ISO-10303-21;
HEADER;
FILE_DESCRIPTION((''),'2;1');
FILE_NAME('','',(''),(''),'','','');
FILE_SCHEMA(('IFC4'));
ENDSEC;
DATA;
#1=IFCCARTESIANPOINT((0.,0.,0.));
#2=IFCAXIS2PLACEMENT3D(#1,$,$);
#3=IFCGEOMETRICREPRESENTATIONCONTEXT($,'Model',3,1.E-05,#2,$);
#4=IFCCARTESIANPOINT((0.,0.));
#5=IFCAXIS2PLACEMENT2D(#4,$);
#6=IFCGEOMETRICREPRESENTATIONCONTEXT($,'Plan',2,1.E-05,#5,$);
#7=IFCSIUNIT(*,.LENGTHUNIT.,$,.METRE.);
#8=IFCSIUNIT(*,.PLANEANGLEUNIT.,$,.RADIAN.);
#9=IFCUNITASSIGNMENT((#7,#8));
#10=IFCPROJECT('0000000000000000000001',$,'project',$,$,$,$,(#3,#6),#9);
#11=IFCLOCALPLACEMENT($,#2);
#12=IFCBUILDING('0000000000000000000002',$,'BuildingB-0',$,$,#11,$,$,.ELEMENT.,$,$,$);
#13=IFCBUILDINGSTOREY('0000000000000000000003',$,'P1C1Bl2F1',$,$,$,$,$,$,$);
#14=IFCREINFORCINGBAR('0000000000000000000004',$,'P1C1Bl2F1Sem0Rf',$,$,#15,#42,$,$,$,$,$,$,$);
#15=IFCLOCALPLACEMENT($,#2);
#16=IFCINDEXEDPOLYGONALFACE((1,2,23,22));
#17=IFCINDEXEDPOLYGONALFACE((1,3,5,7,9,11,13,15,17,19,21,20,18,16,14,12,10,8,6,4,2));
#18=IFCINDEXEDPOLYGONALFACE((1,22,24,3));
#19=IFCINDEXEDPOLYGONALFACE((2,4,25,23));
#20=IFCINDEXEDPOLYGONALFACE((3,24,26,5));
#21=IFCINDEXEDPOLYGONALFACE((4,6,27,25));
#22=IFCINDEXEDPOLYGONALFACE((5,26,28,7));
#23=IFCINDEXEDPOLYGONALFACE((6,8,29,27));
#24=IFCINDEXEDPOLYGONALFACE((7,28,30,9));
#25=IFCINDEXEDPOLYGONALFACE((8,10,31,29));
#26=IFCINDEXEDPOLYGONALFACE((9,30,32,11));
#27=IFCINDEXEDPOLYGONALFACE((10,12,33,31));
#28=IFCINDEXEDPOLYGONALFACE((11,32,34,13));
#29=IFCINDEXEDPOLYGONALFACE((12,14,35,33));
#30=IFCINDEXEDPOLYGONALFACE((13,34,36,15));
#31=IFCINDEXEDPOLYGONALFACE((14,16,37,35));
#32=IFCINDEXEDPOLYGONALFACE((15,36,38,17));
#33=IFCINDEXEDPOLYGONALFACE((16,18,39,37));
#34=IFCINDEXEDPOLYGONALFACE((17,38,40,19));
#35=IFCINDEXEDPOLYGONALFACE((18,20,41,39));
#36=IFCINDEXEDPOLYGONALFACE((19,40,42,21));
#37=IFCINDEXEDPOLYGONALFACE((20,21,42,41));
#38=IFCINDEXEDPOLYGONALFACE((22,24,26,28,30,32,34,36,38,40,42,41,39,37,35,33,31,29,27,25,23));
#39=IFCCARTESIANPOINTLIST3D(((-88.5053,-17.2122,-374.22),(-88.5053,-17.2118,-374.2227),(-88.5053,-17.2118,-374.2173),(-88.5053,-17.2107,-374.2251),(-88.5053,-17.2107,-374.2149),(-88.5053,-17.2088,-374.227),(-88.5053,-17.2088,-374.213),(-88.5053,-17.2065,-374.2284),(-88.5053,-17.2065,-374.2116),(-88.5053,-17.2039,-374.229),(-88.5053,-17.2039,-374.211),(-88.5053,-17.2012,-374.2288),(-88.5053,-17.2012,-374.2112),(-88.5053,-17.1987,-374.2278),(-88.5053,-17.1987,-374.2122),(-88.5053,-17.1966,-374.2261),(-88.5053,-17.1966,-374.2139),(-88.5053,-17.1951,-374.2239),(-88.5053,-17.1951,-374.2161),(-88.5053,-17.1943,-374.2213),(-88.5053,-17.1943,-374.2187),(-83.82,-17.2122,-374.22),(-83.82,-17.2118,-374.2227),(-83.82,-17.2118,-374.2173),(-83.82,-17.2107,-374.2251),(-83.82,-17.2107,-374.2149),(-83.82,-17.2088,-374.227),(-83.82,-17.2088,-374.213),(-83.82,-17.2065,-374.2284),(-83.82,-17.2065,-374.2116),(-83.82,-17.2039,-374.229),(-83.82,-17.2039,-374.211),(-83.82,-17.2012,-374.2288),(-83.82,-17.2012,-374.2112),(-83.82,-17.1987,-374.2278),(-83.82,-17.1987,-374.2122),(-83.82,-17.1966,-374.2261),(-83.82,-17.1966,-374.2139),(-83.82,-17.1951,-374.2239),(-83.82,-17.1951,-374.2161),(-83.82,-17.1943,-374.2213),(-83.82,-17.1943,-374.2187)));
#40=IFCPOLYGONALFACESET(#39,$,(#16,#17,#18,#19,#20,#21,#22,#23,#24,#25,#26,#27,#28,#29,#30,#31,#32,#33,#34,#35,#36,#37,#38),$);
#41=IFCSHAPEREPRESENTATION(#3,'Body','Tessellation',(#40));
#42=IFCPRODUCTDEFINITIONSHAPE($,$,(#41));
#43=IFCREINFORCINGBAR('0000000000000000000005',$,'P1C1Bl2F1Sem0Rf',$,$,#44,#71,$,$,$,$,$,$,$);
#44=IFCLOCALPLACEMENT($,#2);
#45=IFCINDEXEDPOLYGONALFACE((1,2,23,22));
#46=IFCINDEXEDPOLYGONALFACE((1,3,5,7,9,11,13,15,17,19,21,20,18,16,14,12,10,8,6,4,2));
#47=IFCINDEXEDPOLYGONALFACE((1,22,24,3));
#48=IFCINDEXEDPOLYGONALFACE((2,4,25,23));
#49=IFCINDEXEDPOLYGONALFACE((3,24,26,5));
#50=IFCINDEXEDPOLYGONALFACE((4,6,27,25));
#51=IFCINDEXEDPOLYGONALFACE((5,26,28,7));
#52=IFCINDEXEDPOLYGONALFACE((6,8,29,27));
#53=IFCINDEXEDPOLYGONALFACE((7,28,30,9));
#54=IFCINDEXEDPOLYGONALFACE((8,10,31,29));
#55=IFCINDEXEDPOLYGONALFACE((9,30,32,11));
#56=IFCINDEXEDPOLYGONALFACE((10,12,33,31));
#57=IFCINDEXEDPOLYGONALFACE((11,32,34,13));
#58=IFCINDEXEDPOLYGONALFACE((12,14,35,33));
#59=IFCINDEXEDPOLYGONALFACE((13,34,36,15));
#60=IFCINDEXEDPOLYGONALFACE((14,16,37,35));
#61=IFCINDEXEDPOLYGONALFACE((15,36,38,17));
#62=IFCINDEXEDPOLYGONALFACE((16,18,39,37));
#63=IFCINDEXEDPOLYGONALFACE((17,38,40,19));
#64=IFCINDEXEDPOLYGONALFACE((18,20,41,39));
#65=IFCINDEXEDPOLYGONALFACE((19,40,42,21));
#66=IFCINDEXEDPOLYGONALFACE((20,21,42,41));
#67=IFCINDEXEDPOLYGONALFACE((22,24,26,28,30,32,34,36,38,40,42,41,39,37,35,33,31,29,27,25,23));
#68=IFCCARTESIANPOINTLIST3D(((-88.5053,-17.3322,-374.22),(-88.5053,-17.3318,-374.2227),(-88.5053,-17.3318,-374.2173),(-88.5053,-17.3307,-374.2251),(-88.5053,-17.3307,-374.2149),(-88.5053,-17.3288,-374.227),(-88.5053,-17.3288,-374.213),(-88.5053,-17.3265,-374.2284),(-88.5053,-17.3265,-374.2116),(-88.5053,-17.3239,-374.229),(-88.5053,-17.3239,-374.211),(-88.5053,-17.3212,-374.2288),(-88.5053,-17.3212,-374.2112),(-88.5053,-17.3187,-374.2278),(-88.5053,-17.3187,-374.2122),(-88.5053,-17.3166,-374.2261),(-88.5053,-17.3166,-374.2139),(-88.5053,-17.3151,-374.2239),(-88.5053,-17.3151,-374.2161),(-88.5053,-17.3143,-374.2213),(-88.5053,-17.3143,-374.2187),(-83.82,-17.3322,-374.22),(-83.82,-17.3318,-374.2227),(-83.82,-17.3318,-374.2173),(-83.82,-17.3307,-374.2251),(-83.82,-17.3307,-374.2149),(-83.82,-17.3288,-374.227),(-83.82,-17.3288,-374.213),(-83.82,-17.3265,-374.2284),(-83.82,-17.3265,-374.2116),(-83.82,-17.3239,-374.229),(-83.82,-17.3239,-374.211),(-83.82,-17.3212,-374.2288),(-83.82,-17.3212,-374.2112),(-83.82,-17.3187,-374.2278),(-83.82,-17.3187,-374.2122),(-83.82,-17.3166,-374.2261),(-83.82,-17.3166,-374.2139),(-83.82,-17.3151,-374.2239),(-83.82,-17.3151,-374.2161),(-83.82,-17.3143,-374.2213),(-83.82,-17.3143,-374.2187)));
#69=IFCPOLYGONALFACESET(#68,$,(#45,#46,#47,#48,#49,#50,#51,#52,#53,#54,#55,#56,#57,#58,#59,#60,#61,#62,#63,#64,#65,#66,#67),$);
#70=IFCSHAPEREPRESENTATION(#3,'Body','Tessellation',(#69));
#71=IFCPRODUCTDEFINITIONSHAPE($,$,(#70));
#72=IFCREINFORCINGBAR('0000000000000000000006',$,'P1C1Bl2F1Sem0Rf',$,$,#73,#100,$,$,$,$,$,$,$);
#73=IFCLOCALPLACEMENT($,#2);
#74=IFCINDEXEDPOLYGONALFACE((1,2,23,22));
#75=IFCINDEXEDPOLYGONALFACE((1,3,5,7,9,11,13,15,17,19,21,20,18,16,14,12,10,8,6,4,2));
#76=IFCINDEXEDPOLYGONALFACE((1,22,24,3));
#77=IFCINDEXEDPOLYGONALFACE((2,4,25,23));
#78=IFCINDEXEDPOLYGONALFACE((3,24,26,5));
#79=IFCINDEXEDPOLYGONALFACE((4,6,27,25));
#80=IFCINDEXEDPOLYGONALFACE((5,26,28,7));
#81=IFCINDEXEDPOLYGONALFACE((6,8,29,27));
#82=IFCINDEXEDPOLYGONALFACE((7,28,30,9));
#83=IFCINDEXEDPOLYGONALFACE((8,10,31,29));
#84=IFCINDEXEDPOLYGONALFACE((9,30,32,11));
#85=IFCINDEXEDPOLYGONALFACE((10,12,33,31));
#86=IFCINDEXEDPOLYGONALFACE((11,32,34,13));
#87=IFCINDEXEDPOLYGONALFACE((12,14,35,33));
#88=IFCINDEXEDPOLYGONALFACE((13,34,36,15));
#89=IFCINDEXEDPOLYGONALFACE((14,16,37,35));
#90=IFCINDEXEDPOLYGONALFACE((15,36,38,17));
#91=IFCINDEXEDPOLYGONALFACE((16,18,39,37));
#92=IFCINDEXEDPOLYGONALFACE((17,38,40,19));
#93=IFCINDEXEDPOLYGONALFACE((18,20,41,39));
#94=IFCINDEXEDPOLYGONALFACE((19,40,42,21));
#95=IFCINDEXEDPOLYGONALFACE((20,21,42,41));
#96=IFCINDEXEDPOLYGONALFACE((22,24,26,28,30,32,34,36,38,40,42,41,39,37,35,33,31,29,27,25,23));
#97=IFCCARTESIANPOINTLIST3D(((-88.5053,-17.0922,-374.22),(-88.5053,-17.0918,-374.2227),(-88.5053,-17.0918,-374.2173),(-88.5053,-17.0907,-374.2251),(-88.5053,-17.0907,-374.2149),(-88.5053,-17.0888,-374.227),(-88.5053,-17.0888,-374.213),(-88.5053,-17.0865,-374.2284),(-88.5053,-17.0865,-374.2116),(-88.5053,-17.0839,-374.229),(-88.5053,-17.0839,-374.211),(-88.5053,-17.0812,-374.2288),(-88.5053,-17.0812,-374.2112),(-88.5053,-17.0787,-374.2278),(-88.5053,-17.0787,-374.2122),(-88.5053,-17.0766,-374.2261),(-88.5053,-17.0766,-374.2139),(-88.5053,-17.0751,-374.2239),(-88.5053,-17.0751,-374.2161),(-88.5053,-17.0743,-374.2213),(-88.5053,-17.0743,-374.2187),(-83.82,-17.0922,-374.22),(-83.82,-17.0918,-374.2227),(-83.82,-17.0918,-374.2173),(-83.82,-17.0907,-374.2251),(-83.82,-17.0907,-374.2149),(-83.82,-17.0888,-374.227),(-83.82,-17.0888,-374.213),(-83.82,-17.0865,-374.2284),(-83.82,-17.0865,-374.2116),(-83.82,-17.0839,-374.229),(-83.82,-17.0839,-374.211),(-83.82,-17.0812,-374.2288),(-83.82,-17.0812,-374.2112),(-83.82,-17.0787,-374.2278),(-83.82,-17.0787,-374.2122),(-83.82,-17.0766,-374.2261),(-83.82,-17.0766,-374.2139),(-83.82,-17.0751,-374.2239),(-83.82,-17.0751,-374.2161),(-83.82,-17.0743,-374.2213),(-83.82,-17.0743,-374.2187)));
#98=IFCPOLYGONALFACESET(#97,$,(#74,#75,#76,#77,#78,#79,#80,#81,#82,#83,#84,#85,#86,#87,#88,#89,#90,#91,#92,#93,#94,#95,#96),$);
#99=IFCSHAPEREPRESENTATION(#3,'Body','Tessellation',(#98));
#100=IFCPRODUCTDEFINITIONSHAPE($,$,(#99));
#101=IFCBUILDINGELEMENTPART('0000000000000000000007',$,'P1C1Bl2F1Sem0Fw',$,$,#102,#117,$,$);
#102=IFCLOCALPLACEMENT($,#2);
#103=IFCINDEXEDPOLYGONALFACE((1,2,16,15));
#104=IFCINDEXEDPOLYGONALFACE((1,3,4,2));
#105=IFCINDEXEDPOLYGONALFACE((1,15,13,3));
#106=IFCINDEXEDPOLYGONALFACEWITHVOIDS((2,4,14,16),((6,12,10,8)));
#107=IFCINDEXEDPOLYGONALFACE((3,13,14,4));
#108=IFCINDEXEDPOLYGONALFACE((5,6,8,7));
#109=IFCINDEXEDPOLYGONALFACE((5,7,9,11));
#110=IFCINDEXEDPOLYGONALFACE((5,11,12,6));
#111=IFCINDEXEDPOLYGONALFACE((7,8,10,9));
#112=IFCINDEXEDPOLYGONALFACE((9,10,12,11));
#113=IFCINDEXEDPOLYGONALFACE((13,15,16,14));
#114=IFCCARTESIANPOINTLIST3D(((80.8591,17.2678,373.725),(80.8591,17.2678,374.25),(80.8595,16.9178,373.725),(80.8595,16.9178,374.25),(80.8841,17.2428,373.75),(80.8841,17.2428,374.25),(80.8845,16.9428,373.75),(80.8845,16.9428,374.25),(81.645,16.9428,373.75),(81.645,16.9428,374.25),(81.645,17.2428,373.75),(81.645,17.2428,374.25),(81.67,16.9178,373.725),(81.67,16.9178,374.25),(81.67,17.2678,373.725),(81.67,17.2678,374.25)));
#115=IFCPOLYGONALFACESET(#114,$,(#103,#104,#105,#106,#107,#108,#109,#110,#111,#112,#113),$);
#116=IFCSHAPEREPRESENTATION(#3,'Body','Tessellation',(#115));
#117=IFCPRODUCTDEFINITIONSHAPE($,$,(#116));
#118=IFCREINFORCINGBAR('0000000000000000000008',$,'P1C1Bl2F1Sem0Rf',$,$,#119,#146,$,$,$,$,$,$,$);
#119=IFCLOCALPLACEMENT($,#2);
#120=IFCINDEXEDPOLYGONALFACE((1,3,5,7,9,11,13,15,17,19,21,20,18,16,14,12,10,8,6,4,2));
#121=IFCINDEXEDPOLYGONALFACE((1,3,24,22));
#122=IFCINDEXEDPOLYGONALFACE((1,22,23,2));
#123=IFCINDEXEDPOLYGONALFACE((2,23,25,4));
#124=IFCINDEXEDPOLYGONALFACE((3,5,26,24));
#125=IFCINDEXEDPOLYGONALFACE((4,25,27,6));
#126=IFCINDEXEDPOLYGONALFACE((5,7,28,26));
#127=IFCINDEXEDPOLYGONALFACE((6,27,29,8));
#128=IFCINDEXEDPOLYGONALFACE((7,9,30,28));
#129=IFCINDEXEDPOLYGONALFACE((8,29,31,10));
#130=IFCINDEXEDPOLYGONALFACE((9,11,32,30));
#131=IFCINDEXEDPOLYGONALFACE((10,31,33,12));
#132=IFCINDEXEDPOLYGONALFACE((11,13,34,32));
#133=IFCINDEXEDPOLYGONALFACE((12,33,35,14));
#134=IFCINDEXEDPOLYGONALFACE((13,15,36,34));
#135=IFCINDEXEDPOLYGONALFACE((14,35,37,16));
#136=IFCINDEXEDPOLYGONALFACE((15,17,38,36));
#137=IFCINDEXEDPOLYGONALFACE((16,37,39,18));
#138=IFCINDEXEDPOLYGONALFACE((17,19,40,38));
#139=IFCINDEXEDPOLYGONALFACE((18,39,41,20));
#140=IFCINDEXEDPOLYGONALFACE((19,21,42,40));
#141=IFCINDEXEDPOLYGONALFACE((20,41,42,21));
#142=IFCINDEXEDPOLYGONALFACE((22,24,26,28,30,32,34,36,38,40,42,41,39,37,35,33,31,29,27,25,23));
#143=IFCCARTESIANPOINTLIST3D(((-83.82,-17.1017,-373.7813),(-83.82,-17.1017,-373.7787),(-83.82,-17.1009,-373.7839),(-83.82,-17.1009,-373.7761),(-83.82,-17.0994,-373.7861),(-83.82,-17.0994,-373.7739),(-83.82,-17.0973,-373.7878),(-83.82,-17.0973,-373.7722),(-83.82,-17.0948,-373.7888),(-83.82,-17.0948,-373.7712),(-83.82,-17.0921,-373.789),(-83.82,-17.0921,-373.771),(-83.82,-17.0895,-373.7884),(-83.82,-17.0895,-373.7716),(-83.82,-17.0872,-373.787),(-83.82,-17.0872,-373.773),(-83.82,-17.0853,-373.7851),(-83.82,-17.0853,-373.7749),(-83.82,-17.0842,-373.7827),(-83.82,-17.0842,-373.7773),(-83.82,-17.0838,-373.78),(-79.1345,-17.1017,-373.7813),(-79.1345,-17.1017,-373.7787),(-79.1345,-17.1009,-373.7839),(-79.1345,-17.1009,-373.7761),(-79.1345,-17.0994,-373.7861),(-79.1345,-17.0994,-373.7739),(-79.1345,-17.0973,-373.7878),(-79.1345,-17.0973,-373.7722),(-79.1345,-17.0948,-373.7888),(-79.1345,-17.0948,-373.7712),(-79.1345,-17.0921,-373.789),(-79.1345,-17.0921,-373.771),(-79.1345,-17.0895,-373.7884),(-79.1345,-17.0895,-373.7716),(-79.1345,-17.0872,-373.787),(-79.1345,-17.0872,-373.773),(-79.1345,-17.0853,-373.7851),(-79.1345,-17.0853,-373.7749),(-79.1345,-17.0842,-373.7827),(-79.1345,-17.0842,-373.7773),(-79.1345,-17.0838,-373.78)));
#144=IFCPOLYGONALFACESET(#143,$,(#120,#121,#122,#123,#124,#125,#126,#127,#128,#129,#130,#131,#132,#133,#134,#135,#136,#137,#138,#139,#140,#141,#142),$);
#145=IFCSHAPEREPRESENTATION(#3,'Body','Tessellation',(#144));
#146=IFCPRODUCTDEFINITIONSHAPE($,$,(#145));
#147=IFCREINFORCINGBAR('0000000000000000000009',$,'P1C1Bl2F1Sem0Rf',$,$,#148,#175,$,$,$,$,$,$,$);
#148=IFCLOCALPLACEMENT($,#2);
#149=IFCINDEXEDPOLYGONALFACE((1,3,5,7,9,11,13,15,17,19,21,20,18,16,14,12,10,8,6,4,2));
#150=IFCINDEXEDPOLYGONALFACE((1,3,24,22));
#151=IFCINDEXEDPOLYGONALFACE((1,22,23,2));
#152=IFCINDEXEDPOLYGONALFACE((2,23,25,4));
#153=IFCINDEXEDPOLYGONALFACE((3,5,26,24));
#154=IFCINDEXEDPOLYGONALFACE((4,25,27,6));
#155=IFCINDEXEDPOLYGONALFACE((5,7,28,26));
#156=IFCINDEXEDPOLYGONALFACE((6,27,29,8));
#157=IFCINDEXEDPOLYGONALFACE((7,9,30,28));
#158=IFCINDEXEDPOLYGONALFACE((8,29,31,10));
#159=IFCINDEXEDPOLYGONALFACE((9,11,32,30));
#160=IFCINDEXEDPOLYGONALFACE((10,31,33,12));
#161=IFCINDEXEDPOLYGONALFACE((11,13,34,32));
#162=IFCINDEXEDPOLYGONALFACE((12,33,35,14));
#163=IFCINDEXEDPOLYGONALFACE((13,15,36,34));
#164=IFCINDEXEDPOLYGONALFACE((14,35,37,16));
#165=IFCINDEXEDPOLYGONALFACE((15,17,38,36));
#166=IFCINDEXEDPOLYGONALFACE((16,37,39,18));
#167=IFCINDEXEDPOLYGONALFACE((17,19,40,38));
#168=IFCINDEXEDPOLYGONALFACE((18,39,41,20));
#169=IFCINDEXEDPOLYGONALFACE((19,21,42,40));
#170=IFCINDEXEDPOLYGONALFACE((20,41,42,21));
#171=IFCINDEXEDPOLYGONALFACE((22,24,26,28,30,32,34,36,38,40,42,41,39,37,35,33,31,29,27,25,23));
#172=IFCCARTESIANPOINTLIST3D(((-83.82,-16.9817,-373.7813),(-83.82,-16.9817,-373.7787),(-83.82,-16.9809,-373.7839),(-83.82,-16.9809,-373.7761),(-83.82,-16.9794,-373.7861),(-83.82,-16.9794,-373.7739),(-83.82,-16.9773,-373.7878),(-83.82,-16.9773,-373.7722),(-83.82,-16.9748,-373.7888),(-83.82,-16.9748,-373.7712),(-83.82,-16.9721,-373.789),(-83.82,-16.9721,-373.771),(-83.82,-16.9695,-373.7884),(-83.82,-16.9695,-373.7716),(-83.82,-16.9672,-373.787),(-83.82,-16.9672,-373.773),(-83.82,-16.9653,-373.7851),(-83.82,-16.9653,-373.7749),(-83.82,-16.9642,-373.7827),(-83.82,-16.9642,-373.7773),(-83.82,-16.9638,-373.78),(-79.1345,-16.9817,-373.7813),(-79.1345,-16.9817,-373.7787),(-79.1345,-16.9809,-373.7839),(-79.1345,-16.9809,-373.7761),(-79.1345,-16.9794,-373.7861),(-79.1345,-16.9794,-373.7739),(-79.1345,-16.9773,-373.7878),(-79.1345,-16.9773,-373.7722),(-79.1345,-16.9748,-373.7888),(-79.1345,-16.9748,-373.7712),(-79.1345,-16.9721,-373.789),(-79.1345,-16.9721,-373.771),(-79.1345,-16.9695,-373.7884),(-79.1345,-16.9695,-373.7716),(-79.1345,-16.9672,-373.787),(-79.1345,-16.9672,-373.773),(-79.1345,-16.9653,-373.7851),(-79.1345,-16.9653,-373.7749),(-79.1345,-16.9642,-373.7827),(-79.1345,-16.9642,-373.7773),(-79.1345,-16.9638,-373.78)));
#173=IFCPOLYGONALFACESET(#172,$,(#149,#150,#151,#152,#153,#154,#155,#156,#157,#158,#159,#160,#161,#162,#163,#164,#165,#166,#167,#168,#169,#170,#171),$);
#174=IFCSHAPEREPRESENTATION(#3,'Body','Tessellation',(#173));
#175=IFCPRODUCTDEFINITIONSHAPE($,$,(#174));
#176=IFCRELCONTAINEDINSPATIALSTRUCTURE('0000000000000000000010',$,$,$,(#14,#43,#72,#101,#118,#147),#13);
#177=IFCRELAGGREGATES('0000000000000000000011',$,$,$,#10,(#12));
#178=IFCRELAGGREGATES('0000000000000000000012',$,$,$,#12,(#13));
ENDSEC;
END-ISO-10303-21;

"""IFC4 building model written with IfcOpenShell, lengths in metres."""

from ifc_helpers import new_model, entity, si_unit, origin, origin_2d, place, context, project, spatial, polyline, outline, extrude, element, save


model = new_model("IFC4")

# Units and contexts
model_context = context("Model", 3, precision=1e-05, world=origin())
plan_context = context("Plan", 2, precision=1e-05, world=origin_2d())
ifc_project = project(units=[si_unit("LENGTHUNIT", "METRE"), si_unit("PLANEANGLEUNIT", "RADIAN")], contexts=[model_context, plan_context])

# Building, storey
building_placement = place(None, origin())
building = spatial("IfcBuilding", under=ifc_project, at=building_placement, Name="BuildingB-0", CompositionType="ELEMENT")
storey = spatial("IfcBuildingStorey", under=building, Name="P1C1Bl2F1")

# Reinforcing bars
element("IfcReinforcingBar", 1, inside=storey, Name="P1C1Bl2F1Sem0Rf", context=model_context, shape_type="SweptSolid", body=[
    entity("IfcSurfaceCurveSweptAreaSolid", entity("IfcCircleProfileDef", "AREA", None, None, 0.009), None, entity("IfcPolyline", [entity("IfcCartesianPoint", [88.5053, 17.2032, 374.22]), entity("IfcCartesianPoint", [83.82, 17.2032, 374.22])]), None, None, entity("IfcPlane", entity("IfcAxis2Placement3D", entity("IfcCartesianPoint", [88.5053, 17.2032, 374.22]), entity("IfcDirection", [0.0, 0.0, 1.0]), entity("IfcDirection", [1.0, 0.0, 0.0])))),
])
element("IfcReinforcingBar", 2, inside=storey, Name="P1C1Bl2F1Sem0Rf", context=model_context, shape_type="SweptSolid", body=[
    entity("IfcSurfaceCurveSweptAreaSolid", entity("IfcCircleProfileDef", "AREA", None, None, 0.009), None, entity("IfcPolyline", [entity("IfcCartesianPoint", [88.5053, 17.3232, 374.22]), entity("IfcCartesianPoint", [83.82, 17.3232, 374.22])]), None, None, entity("IfcPlane", entity("IfcAxis2Placement3D", entity("IfcCartesianPoint", [88.5053, 17.3232, 374.22]), entity("IfcDirection", [0.0, 0.0, 1.0]), entity("IfcDirection", [1.0, 0.0, 0.0])))),
])
element("IfcReinforcingBar", 3, inside=storey, Name="P1C1Bl2F1Sem0Rf", context=model_context, shape_type="SweptSolid", body=[
    entity("IfcSurfaceCurveSweptAreaSolid", entity("IfcCircleProfileDef", "AREA", None, None, 0.009), None, entity("IfcPolyline", [entity("IfcCartesianPoint", [88.5053, 17.0832, 374.22]), entity("IfcCartesianPoint", [83.82, 17.0832, 374.22])]), None, None, entity("IfcPlane", entity("IfcAxis2Placement3D", entity("IfcCartesianPoint", [88.5053, 17.0832, 374.22]), entity("IfcDirection", [0.0, 0.0, 1.0]), entity("IfcDirection", [1.0, 0.0, 0.0])))),
])

# Building element part, opening
building_element_part_1 = element("IfcBuildingElementPart", 4, inside=storey, Name="P1C1Bl2F1Sem0Fw", context=model_context, shape_type="SweptSolid", body=[
    extrude(outline(polyline([(81.67, 16.9178, 373.725), (80.8595, 16.9178, 373.725), (80.8591, 17.2678, 373.725), (81.67, 17.2678, 373.725), (81.67, 16.9178, 373.725)])), None, (0.0, 0.0, 1.0), 0.525),
])
element("IfcOpeningElement", 5, inside=storey, cuts=building_element_part_1, context=model_context, shape_type="SweptSolid", body=[
    extrude(outline(polyline([(81.645, 16.9428, 373.75), (80.8845, 16.9428, 373.75), (80.8841, 17.2428, 373.75), (81.645, 17.2428, 373.75), (81.645, 16.9428, 373.75)])), None, (0.0, 0.0, 1.0), 0.5),
])

# Reinforcing bars
element("IfcReinforcingBar", 6, inside=storey, Name="P1C1Bl2F1Sem0Rf", context=model_context, shape_type="SweptSolid", body=[
    entity("IfcSurfaceCurveSweptAreaSolid", entity("IfcCircleProfileDef", "AREA", None, None, 0.009), None, entity("IfcPolyline", [entity("IfcCartesianPoint", [79.1345, 17.0928, 373.78]), entity("IfcCartesianPoint", [83.82, 17.0928, 373.78])]), None, None, entity("IfcPlane", entity("IfcAxis2Placement3D", entity("IfcCartesianPoint", [79.1345, 17.0928, 373.78]), entity("IfcDirection", [0.0, 0.0, 1.0]), entity("IfcDirection", [1.0, 0.0, 0.0])))),
])
element("IfcReinforcingBar", 7, inside=storey, Name="P1C1Bl2F1Sem0Rf", context=model_context, shape_type="SweptSolid", body=[
    entity("IfcSurfaceCurveSweptAreaSolid", entity("IfcCircleProfileDef", "AREA", None, None, 0.009), None, entity("IfcPolyline", [entity("IfcCartesianPoint", [79.1345, 16.9728, 373.78]), entity("IfcCartesianPoint", [83.82, 16.9728, 373.78])]), None, None, entity("IfcPlane", entity("IfcAxis2Placement3D", entity("IfcCartesianPoint", [79.1345, 16.9728, 373.78]), entity("IfcDirection", [0.0, 0.0, 1.0]), entity("IfcDirection", [1.0, 0.0, 0.0])))),
])

save(model, "model.ifc")
